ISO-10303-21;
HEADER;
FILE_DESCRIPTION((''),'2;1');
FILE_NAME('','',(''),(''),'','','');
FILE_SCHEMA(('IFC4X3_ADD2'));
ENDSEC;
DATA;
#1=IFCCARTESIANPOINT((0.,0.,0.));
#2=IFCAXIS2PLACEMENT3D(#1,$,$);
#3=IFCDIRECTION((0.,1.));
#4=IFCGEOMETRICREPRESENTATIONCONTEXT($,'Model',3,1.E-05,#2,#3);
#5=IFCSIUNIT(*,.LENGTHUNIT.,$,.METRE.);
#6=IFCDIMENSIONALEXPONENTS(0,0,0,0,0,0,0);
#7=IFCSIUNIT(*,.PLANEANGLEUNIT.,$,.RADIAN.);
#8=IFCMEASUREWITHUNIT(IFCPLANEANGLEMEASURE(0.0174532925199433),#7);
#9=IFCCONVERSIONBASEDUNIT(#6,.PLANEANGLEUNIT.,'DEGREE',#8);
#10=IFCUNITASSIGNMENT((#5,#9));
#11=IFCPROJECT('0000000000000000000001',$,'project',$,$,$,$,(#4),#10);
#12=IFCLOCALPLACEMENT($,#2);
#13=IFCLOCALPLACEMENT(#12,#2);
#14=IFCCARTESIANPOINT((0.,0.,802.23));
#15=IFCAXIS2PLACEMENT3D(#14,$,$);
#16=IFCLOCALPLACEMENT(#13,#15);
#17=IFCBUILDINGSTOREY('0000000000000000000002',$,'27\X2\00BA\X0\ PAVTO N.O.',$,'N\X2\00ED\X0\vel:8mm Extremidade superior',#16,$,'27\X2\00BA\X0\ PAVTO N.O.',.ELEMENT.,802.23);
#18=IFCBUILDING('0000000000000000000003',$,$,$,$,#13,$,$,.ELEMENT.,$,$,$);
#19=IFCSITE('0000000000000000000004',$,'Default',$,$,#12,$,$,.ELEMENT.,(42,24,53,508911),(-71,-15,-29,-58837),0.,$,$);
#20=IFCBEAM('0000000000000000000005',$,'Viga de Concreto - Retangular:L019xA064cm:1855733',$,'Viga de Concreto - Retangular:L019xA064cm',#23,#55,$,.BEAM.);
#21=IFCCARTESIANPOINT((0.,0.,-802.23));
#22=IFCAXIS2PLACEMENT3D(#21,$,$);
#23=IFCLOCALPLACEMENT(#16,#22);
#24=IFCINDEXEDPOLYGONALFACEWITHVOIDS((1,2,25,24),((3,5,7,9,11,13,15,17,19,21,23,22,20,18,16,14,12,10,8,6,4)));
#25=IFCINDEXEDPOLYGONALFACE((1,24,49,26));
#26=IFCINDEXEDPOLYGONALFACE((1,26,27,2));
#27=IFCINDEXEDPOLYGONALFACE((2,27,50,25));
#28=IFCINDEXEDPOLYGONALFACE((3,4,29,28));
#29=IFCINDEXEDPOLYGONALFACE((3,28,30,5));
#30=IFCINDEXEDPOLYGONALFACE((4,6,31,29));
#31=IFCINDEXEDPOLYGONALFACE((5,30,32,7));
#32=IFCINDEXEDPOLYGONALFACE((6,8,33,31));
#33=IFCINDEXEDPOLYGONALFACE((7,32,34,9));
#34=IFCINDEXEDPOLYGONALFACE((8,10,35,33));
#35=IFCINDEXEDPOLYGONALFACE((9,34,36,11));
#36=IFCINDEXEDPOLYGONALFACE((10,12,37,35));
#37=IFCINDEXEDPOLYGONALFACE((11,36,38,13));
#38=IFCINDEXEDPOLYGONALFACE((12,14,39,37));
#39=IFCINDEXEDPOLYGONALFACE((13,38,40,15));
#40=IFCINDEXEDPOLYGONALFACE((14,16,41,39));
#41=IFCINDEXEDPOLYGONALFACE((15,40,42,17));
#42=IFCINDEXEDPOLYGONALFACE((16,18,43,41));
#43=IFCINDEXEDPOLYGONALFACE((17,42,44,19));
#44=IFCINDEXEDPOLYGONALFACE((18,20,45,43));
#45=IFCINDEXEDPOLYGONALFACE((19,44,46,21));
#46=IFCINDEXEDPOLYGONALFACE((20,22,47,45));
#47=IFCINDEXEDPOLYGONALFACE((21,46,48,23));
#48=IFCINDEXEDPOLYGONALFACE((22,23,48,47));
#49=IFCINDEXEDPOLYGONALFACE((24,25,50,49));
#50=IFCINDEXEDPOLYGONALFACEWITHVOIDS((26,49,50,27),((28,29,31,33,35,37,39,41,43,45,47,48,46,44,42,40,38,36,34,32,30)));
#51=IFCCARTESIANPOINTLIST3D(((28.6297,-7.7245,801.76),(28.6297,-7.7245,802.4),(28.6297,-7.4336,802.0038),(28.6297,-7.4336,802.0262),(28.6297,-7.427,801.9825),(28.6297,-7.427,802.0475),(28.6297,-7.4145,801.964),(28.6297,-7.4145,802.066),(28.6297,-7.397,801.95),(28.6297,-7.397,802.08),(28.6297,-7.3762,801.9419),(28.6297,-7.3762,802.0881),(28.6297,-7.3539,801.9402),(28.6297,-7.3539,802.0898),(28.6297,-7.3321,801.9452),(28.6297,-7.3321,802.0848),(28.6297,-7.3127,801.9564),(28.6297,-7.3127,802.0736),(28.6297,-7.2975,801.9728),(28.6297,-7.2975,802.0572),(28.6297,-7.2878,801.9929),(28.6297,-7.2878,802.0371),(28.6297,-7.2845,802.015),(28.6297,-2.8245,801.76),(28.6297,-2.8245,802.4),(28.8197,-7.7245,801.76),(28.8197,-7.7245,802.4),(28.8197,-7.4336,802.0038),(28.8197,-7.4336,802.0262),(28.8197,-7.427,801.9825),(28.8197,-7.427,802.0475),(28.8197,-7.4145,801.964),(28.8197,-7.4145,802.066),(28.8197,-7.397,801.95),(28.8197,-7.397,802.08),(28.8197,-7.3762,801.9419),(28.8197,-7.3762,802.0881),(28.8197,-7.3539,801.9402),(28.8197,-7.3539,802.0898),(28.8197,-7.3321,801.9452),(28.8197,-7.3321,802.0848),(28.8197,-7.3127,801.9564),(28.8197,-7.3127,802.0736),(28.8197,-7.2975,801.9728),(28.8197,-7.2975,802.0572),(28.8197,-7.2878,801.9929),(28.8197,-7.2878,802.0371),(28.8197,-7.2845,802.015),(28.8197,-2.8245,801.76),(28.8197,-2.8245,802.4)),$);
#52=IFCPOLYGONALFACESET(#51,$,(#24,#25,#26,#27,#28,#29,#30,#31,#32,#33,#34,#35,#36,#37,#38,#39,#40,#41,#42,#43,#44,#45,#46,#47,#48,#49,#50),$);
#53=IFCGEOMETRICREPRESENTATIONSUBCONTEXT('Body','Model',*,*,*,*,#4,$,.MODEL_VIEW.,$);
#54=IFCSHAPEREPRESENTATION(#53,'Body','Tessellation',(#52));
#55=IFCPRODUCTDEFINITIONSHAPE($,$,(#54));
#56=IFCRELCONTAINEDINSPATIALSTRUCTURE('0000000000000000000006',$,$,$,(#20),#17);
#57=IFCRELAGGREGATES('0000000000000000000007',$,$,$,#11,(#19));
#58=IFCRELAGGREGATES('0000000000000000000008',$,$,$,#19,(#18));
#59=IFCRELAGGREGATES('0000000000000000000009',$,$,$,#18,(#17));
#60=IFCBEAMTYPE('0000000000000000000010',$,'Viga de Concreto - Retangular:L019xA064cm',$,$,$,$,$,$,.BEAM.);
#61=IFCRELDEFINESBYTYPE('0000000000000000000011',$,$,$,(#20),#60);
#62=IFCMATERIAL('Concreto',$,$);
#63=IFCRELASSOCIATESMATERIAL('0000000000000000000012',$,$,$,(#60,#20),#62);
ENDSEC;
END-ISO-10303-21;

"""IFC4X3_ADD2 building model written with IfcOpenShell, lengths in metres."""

from ifc_helpers import new_model, entity, si_unit, converted_unit, direction, frame, frame_2d, origin, place, context, subcontext, project, spatial, rectangle, circle, extrude, boolean, source, transform, mapped, material, material_profile, profile_set, type_object, type_shapes, element, save


model = new_model("IFC4X3_ADD2")

# Units and contexts
model_context = context("Model", 3, precision=1e-05, world=origin(), true_north=direction((0.0, 1.0)))
body_context = subcontext(model_context, "Body", "Model", "MODEL_VIEW")
ifc_project = project(units=[si_unit("LENGTHUNIT", "METRE"), converted_unit("PLANEANGLEUNIT", "DEGREE", entity("IfcPlaneAngleMeasure", 0.0174532925199433), si_unit("PLANEANGLEUNIT", "RADIAN"), dimensions=[0, 0, 0, 0, 0, 0, 0])], contexts=[model_context])

# Site, building, storey
site_placement = place(None, origin())
site = spatial("IfcSite", under=ifc_project, at=site_placement, Name="Default", CompositionType="ELEMENT", RefLatitude=(42, 24, 53, 508911), RefLongitude=(-71, -15, -29, -58837), RefElevation=0.0)
building_placement = place(site_placement, origin())
building = spatial("IfcBuilding", under=site, at=building_placement, CompositionType="ELEMENT")
storey_placement = place(building_placement, frame((0.0, 0.0, 802.23)))
storey = spatial("IfcBuildingStorey", under=building, at=storey_placement, Name="27º PAVTO N.O.", ObjectType="Nível:8mm Extremidade superior", LongName="27º PAVTO N.O.", CompositionType="ELEMENT", Elevation=802.23)

# Beam
ifc_material = material(Name="Concreto")
ifc_material_profile_1 = material_profile(ifc_material, rectangle(XDim=0.64, YDim=0.19, at=frame_2d((0.0, 0.0), x_axis=(1.0, 0.0))), Name="L019xA064cm")
ifc_profile_set_1 = profile_set([ifc_material_profile_1], Name="L019xA064cm")
beam_type_1 = type_object("IfcBeamType", Name="Viga de Concreto - Retangular:L019xA064cm", PredefinedType="BEAM", material=ifc_profile_set_1)
shared_shape_1 = source(origin(), body_context, "Body", "CSG", [
    boolean("DIFFERENCE", extrude(rectangle(XDim=0.64, YDim=0.19, at=frame_2d((0.0, 0.0), x_axis=(0.0, 1.0))), frame((28.7247, -7.7245, 802.08), z_axis=(0.0, 1.0, 0.0), x_axis=(-1.0, 0.0, 0.0)), (0.0, 0.0, 1.0), 4.9), extrude(circle(Radius=0.075, at=frame_2d((0.0, 0.0), x_axis=(1.0, 0.0))), frame((28.8197, -7.3595, 802.015), z_axis=(-1.0, 0.0, 0.0), x_axis=(0.0, 1.0, 0.0)), (0.0, 0.0, 1.0), 0.19)),
])
type_shapes(beam_type_1, [shared_shape_1])
beam_1_placement = place(storey_placement, frame((0.0, 0.0, -802.23)))
element("IfcBeam", 1, at=beam_1_placement, inside=storey, type_object=beam_type_1, material=ifc_material, Name="Viga de Concreto - Retangular:L019xA064cm:1855733", ObjectType="Viga de Concreto - Retangular:L019xA064cm", PredefinedType="BEAM", context=body_context, shape_type="MappedRepresentation", body=[
    mapped(shared_shape_1, transform((0.0, 0.0, 0.0), scale=1.0)),
])

save(model, "model.ifc")
